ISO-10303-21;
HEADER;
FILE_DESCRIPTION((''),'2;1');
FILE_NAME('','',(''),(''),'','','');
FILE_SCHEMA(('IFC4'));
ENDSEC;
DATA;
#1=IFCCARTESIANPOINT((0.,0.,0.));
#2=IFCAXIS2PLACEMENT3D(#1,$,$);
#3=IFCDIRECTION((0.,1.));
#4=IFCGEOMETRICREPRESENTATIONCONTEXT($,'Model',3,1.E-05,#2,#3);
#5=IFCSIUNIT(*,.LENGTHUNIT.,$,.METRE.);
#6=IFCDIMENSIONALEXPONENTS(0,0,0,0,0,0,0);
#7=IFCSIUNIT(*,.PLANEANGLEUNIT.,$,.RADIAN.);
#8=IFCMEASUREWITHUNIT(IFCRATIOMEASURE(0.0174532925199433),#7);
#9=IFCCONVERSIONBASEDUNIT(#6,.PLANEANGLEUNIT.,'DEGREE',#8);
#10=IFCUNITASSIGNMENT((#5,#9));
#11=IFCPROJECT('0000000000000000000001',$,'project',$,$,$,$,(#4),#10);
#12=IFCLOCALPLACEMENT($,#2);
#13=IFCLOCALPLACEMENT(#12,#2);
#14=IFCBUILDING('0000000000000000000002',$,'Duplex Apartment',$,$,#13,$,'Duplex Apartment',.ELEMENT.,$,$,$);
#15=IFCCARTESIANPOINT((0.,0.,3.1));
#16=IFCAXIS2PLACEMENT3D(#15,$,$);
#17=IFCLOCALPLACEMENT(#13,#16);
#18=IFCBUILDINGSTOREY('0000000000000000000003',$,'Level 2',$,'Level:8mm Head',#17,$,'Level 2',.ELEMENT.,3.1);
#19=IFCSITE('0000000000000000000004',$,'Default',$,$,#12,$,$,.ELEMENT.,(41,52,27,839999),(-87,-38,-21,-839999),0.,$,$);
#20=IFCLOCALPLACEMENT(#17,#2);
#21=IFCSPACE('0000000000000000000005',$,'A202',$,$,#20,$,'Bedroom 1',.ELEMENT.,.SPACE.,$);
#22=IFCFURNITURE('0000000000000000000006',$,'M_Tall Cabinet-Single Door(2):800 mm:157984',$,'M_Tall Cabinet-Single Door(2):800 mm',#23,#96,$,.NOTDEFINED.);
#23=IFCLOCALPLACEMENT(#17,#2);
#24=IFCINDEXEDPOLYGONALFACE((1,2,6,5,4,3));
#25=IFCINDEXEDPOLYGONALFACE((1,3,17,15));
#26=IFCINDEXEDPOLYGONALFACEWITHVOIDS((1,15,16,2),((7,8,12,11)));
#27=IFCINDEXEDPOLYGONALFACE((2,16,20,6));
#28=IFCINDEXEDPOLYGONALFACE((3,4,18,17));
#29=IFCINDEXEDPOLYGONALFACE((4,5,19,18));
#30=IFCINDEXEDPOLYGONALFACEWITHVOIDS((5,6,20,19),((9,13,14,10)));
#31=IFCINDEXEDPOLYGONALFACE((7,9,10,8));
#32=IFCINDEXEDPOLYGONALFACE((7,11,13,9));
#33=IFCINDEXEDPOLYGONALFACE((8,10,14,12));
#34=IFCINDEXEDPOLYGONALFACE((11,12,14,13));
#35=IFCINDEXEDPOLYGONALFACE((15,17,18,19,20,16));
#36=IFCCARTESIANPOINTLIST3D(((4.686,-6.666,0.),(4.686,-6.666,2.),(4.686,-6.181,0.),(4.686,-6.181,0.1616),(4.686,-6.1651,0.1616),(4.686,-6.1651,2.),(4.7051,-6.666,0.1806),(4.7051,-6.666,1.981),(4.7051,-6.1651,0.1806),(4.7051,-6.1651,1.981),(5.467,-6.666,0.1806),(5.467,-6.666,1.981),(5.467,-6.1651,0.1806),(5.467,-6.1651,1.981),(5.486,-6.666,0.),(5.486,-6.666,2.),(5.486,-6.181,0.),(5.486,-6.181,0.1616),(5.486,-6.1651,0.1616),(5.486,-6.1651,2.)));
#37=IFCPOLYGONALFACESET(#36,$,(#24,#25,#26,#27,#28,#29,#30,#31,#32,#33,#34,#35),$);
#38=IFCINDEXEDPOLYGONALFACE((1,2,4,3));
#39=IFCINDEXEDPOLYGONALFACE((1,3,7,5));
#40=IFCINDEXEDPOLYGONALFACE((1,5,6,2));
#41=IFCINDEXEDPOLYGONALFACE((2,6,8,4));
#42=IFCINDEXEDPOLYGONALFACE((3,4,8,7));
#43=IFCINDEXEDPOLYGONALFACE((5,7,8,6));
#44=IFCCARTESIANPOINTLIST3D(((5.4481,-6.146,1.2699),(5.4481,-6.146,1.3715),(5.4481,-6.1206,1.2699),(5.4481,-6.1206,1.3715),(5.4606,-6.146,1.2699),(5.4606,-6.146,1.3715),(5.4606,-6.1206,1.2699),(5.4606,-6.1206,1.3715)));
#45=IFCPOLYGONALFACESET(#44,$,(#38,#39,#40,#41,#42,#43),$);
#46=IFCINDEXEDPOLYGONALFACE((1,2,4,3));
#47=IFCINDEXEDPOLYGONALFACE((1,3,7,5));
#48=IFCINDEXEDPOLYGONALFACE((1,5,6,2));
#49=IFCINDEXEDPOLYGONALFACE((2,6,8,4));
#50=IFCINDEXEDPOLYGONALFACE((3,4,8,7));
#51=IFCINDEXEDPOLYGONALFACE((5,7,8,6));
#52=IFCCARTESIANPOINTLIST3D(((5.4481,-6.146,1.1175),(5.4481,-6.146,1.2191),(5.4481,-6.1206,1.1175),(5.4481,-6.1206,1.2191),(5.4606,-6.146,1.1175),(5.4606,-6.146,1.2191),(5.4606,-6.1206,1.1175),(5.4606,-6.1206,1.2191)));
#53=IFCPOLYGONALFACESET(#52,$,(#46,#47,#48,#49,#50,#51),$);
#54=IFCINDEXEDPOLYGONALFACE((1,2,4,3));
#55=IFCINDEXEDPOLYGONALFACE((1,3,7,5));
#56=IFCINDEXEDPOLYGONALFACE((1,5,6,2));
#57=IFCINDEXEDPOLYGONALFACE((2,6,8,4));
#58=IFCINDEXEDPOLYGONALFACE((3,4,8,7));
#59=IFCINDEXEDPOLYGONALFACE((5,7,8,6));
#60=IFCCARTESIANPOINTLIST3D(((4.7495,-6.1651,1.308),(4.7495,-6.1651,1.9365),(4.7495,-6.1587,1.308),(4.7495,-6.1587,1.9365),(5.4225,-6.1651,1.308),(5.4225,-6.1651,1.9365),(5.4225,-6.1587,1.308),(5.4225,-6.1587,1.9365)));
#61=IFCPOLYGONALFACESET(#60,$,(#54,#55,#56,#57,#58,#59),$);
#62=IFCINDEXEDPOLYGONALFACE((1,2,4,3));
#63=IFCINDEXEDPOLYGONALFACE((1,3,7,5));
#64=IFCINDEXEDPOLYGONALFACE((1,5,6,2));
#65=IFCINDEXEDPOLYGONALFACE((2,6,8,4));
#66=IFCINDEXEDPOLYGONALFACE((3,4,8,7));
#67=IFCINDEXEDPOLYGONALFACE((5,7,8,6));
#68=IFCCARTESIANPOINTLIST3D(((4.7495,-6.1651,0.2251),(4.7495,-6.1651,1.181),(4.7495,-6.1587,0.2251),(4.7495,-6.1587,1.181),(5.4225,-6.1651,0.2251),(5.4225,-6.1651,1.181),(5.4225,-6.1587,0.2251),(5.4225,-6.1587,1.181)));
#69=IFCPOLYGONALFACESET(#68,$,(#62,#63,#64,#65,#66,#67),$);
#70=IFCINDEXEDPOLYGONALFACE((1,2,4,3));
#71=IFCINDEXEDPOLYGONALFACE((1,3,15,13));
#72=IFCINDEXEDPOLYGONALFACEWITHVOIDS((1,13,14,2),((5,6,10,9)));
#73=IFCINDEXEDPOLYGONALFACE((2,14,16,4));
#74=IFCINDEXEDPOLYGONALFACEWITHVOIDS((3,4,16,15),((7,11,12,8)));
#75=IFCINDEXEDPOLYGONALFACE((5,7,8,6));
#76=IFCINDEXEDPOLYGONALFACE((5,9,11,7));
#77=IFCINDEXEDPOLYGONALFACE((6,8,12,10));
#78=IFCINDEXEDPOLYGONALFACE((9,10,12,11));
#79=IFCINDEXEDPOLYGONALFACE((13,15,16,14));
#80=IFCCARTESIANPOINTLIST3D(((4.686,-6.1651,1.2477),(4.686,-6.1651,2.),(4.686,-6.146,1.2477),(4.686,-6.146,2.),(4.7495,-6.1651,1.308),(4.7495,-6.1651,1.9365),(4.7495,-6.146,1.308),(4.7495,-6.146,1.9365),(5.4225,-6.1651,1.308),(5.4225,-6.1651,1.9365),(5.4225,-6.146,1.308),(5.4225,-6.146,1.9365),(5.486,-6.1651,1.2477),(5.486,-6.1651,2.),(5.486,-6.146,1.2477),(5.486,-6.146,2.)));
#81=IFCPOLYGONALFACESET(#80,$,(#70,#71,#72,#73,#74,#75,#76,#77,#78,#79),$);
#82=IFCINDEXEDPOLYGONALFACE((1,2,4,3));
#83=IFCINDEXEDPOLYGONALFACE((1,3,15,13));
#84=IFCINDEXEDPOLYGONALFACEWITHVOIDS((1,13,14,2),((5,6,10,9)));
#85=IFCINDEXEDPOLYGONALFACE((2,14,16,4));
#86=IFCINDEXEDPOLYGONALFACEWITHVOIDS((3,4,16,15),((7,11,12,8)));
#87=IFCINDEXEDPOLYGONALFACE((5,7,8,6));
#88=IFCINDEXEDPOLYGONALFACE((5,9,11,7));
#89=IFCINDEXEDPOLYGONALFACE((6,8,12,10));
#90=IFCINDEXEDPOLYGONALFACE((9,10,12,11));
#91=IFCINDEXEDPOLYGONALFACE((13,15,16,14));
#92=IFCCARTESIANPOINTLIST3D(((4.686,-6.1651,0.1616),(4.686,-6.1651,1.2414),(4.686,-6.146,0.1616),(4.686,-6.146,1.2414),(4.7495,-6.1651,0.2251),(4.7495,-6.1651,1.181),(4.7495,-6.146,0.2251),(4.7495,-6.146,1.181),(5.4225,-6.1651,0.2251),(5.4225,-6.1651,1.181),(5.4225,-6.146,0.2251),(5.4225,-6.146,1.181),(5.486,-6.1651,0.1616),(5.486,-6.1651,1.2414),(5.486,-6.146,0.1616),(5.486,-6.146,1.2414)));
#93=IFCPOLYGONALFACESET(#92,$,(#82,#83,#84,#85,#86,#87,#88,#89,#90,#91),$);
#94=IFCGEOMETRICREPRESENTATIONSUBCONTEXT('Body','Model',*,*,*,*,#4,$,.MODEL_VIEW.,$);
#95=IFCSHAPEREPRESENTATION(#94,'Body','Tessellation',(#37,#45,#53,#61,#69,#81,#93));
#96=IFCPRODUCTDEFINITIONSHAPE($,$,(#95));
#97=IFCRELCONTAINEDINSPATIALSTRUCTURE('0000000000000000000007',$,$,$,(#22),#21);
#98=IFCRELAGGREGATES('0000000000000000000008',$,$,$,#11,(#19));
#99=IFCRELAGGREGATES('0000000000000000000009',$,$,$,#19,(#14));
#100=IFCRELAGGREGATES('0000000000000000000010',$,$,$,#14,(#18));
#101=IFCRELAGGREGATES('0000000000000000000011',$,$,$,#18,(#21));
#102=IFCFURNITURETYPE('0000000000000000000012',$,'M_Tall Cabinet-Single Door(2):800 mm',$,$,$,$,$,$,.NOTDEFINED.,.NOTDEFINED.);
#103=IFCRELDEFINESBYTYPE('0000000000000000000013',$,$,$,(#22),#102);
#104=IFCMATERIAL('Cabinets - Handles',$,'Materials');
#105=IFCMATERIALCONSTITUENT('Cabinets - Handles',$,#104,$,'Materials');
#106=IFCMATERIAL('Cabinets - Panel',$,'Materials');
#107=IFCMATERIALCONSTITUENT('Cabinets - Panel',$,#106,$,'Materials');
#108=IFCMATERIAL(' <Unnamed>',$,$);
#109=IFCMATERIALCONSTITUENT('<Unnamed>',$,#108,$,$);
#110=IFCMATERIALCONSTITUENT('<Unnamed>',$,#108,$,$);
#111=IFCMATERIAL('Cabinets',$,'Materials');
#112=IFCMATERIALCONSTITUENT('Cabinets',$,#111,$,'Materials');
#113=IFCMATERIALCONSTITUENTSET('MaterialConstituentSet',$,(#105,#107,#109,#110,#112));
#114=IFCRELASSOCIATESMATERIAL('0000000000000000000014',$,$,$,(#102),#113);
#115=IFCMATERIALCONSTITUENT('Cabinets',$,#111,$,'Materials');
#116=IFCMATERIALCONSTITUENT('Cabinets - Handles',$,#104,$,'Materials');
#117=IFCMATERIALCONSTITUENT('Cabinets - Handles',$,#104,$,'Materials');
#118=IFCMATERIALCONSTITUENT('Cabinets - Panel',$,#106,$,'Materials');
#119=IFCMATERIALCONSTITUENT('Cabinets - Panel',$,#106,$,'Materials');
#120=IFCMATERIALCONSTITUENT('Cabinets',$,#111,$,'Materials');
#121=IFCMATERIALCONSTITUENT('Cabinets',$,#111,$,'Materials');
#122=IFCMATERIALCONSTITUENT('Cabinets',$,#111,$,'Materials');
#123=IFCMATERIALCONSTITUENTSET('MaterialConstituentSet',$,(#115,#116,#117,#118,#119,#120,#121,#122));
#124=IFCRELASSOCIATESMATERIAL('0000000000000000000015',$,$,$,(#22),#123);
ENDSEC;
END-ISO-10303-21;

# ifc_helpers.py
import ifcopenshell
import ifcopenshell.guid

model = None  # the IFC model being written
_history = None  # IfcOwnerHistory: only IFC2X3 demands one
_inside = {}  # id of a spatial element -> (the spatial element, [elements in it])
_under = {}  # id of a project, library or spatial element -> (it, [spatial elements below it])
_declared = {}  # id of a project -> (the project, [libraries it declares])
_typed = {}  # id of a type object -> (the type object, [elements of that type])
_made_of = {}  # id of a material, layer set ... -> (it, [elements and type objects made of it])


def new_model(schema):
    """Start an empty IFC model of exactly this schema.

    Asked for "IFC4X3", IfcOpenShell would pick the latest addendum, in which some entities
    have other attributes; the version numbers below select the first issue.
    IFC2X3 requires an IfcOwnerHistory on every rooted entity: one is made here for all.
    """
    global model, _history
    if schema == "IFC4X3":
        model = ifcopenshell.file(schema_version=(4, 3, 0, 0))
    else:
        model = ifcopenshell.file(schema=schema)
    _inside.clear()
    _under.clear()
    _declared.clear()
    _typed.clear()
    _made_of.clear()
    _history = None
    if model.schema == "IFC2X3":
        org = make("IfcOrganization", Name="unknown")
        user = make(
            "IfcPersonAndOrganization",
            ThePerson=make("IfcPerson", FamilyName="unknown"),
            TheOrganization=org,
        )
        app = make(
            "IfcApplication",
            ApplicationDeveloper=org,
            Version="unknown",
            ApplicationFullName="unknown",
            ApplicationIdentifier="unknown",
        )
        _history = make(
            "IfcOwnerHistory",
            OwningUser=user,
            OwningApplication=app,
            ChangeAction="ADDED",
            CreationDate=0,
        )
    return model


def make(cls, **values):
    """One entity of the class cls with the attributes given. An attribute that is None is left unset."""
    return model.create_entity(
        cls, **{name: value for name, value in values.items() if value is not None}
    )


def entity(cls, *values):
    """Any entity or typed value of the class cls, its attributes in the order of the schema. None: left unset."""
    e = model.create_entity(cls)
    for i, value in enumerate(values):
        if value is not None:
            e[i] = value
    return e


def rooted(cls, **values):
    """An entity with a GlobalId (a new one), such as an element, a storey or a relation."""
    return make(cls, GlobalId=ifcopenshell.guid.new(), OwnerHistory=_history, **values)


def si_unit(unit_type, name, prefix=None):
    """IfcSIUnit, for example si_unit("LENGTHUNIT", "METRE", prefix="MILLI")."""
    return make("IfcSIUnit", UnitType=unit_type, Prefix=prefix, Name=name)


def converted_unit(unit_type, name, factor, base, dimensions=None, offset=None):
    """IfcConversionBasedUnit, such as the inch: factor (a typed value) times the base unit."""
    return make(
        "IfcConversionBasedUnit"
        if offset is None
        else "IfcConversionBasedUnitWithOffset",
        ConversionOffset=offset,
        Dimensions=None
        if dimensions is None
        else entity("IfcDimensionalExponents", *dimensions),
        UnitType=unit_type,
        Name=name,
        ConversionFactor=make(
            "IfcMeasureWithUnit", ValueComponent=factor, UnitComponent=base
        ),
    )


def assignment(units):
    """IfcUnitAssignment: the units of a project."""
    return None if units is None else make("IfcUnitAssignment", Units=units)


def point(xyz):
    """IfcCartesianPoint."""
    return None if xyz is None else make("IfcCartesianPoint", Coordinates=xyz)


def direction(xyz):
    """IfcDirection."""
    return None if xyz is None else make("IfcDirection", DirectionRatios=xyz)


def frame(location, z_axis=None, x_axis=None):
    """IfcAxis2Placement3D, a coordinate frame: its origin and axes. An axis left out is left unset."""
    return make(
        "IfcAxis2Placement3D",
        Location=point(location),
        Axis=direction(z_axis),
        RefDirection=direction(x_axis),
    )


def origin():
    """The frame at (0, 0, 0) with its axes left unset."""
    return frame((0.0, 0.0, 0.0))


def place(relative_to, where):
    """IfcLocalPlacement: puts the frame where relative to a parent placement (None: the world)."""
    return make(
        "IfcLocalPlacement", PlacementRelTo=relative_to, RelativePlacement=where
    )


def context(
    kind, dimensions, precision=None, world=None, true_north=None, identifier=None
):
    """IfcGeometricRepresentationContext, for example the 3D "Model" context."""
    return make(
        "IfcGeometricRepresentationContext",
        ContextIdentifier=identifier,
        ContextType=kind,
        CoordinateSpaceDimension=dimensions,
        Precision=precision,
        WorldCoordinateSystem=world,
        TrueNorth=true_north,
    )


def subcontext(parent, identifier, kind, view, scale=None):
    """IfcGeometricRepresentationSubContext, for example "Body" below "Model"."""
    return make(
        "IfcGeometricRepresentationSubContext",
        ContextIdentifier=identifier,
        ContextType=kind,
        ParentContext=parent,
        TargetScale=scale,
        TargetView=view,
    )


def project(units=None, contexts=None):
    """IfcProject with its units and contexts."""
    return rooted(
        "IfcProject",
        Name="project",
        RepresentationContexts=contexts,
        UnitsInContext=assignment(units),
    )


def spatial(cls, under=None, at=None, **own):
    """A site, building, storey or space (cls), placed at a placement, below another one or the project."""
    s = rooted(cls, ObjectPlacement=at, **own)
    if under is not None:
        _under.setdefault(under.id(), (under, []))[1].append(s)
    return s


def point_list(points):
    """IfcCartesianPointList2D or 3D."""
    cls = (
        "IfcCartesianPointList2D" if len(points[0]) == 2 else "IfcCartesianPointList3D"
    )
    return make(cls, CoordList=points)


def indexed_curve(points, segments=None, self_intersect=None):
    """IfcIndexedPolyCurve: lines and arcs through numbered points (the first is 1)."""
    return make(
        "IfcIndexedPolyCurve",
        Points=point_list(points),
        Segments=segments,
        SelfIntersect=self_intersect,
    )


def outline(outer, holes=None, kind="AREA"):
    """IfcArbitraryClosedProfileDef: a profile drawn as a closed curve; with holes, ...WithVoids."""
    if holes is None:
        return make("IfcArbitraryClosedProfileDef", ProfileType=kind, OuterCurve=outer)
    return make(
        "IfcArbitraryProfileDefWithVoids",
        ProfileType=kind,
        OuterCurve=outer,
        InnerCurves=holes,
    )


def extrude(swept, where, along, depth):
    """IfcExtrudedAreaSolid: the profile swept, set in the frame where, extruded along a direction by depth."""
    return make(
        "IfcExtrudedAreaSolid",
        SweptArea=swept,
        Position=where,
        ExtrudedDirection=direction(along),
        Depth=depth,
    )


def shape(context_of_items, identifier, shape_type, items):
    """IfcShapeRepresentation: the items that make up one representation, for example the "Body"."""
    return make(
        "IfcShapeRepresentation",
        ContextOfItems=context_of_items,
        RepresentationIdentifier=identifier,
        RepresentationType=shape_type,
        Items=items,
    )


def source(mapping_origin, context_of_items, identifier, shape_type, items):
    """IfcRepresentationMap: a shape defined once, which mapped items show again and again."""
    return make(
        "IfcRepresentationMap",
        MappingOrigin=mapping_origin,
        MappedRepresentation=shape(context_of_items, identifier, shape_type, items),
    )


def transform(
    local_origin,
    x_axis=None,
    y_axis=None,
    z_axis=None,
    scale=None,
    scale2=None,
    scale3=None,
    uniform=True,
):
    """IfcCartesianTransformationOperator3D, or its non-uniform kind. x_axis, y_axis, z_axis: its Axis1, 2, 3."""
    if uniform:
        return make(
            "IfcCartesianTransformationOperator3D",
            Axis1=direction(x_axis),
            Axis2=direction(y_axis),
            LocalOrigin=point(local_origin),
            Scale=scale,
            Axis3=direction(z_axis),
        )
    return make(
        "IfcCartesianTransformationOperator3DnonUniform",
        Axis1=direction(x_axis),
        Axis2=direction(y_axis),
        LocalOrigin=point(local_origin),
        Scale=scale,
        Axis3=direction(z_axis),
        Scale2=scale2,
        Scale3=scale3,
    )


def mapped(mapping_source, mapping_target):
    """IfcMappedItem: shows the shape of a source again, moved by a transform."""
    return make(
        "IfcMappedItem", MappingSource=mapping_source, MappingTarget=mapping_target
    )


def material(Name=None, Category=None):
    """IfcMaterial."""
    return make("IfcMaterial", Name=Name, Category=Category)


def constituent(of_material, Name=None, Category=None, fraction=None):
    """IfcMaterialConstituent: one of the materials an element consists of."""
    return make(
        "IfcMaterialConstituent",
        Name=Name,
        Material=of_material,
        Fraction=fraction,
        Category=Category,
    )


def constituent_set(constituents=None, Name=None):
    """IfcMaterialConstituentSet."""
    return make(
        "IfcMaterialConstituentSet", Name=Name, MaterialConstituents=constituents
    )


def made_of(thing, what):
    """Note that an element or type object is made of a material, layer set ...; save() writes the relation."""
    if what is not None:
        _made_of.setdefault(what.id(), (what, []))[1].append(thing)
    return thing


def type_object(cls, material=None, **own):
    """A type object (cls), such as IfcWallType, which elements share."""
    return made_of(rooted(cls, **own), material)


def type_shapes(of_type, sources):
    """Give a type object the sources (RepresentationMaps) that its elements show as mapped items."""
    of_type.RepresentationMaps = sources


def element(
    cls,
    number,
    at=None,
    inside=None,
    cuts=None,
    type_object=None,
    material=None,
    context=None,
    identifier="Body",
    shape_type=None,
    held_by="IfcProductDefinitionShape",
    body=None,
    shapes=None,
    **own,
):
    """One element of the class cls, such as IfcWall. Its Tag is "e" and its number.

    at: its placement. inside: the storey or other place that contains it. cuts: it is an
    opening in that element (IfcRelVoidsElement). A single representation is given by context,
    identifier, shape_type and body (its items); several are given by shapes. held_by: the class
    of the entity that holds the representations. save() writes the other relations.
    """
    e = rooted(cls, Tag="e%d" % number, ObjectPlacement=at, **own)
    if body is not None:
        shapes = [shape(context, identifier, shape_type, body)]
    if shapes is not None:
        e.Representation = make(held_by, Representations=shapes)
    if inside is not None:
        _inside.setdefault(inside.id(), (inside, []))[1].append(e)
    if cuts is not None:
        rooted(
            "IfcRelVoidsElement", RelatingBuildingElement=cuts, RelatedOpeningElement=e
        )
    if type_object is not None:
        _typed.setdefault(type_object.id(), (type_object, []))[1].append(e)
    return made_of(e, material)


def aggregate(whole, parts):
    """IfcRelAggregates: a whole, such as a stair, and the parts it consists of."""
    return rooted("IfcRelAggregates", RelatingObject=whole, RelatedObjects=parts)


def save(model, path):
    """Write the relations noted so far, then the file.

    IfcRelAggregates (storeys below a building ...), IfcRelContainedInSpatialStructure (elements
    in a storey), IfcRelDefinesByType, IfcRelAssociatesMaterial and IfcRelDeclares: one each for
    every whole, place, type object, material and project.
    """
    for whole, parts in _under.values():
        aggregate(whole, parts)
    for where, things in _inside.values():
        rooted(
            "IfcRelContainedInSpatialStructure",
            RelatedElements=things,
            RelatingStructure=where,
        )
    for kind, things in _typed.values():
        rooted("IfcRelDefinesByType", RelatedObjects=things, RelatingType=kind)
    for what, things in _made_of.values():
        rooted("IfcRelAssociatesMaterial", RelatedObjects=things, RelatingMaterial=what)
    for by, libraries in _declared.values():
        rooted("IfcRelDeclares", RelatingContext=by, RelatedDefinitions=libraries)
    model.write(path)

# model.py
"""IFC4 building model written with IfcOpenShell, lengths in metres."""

from ifc_helpers import new_model, entity, si_unit, converted_unit, direction, frame, origin, place, context, subcontext, project, spatial, indexed_curve, outline, extrude, source, transform, mapped, material, constituent, constituent_set, type_object, type_shapes, element, save


model = new_model("IFC4")

# Units and contexts
model_context = context("Model", 3, precision=1e-05, world=origin(), true_north=direction((0.0, 1.0)))
body_context = subcontext(model_context, "Body", "Model", "MODEL_VIEW")
ifc_project = project(units=[si_unit("LENGTHUNIT", "METRE"), converted_unit("PLANEANGLEUNIT", "DEGREE", entity("IfcRatioMeasure", 0.0174532925199433), si_unit("PLANEANGLEUNIT", "RADIAN"), dimensions=[0, 0, 0, 0, 0, 0, 0])], contexts=[model_context])

# Site, building, storey
site_placement = place(None, origin())
site = spatial("IfcSite", under=ifc_project, at=site_placement, Name="Default", CompositionType="ELEMENT", RefLatitude=(41, 52, 27, 839999), RefLongitude=(-87, -38, -21, -839999), RefElevation=0.0)
building_placement = place(site_placement, origin())
building = spatial("IfcBuilding", under=site, at=building_placement, Name="Duplex Apartment", LongName="Duplex Apartment", CompositionType="ELEMENT")
storey_placement = place(building_placement, frame((0.0, 0.0, 3.1)))
storey = spatial("IfcBuildingStorey", under=building, at=storey_placement, Name="Level 2", ObjectType="Level:8mm Head", LongName="Level 2", CompositionType="ELEMENT", Elevation=3.1)

# Shared definitions
ifc_material_1 = material(Name="Cabinets", Category="Materials")
ifc_material_2 = material(Name="Cabinets - Handles", Category="Materials")
ifc_material_3 = material(Name="Cabinets - Panel", Category="Materials")
ifc_material_4 = material(Name=" <Unnamed>")

# Shared definitions
space_1_placement = place(storey_placement, origin())
space_1 = spatial("IfcSpace", under=storey, at=space_1_placement, Name="A202", LongName="Bedroom 1", CompositionType="ELEMENT", PredefinedType="SPACE")

# Furniture, opening
ifc_constituent_1 = constituent(ifc_material_1, Name="Cabinets", Category="Materials")
ifc_constituent_2 = constituent(ifc_material_2, Name="Cabinets - Handles", Category="Materials")
ifc_constituent_3 = constituent(ifc_material_2, Name="Cabinets - Handles", Category="Materials")
ifc_constituent_4 = constituent(ifc_material_3, Name="Cabinets - Panel", Category="Materials")
ifc_constituent_5 = constituent(ifc_material_3, Name="Cabinets - Panel", Category="Materials")
ifc_constituent_6 = constituent(ifc_material_1, Name="Cabinets", Category="Materials")
ifc_constituent_7 = constituent(ifc_material_1, Name="Cabinets", Category="Materials")
ifc_constituent_8 = constituent(ifc_material_1, Name="Cabinets", Category="Materials")
ifc_constituent_set_1 = constituent_set(constituents=[ifc_constituent_1, ifc_constituent_2, ifc_constituent_3, ifc_constituent_4, ifc_constituent_5, ifc_constituent_6, ifc_constituent_7, ifc_constituent_8], Name="MaterialConstituentSet")
ifc_constituent_9 = constituent(ifc_material_2, Name="Cabinets - Handles", Category="Materials")
ifc_constituent_10 = constituent(ifc_material_3, Name="Cabinets - Panel", Category="Materials")
ifc_constituent_11 = constituent(ifc_material_4, Name="<Unnamed>")
ifc_constituent_12 = constituent(ifc_material_4, Name="<Unnamed>")
ifc_constituent_13 = constituent(ifc_material_1, Name="Cabinets", Category="Materials")
ifc_constituent_set_2 = constituent_set(constituents=[ifc_constituent_9, ifc_constituent_10, ifc_constituent_11, ifc_constituent_12, ifc_constituent_13], Name="MaterialConstituentSet")
furniture_type_1 = type_object("IfcFurnitureType", Name="M_Tall Cabinet-Single Door(2):800 mm", AssemblyPlace="NOTDEFINED", PredefinedType="NOTDEFINED", material=ifc_constituent_set_2)
shared_shape_1 = source(origin(), body_context, "Body", "SweptSolid", [
    extrude(outline(indexed_curve([(-0.5589, -0.1723), (1.2795, -0.1723), (1.2795, 0.3286), (-0.7205, 0.3286), (-0.7205, -0.1563), (-0.5589, -0.1563), (-0.5589, -0.1723)], self_intersect=False)), frame((-0.3813, 0.3286, 0.7205), z_axis=(1.0, 0.0, 0.0), x_axis=(0.0, 0.0, 1.0)), (0.0, 0.0, 1.0), 0.8),
    extrude(outline(indexed_curve([(-0.0063, -0.0127), (0.0063, -0.0127), (0.0063, 0.0127), (-0.0063, 0.0127), (-0.0063, -0.0127)], self_intersect=False)), frame((0.3871, 0.5327, 1.2699), z_axis=(0.0, 0.0, 1.0), x_axis=(-1.0, 0.0, 0.0)), (0.0, 0.0, 1.0), 0.1016),
    extrude(outline(indexed_curve([(-0.0063, -0.0127), (0.0063, -0.0127), (0.0063, 0.0127), (-0.0063, 0.0127), (-0.0063, -0.0127)], self_intersect=False)), frame((0.3871, 0.5327, 1.1175), z_axis=(0.0, 0.0, 1.0), x_axis=(-1.0, 0.0, 0.0)), (0.0, 0.0, 1.0), 0.1016),
    extrude(outline(indexed_curve([(-0.3365, -0.0032), (0.3365, -0.0032), (0.3365, 0.0032), (-0.3365, 0.0032), (-0.3365, -0.0032)], self_intersect=False)), frame((0.0187, 0.5041, 1.308), z_axis=(0.0, 0.0, 1.0), x_axis=(-1.0, 0.0, 0.0)), (0.0, 0.0, 1.0), 0.6285),
    extrude(outline(indexed_curve([(-0.3365, -0.0032), (0.3365, -0.0032), (0.3365, 0.0032), (-0.3365, 0.0032), (-0.3365, -0.0032)], self_intersect=False)), frame((0.0187, 0.5041, 0.2251), z_axis=(0.0, 0.0, 1.0), x_axis=(-1.0, 0.0, 0.0)), (0.0, 0.0, 1.0), 0.956),
    extrude(outline(indexed_curve([(-0.3761, -0.4), (0.3761, -0.4), (0.3761, 0.4), (-0.3761, 0.4), (-0.3761, -0.4)], self_intersect=False), holes=[indexed_curve([(-0.3126, -0.3365), (-0.3126, 0.3365), (0.3158, 0.3365), (0.3158, -0.3365), (-0.3126, -0.3365)], self_intersect=False)]), frame((0.0187, 0.501, 1.6239), z_axis=(0.0, 1.0, 0.0), x_axis=(0.0, 0.0, -1.0)), (0.0, 0.0, 1.0), 0.0191),
    extrude(outline(indexed_curve([(-0.4, -0.5399), (0.4, -0.5399), (0.4, 0.5399), (-0.4, 0.5399), (-0.4, -0.5399)], self_intersect=False), holes=[indexed_curve([(-0.3365, 0.4796), (0.3365, 0.4796), (0.3365, -0.4764), (-0.3365, -0.4764), (-0.3365, 0.4796)], self_intersect=False)]), frame((0.0187, 0.501, 0.7015), z_axis=(0.0, 1.0, 0.0), x_axis=(-1.0, 0.0, 0.0)), (0.0, 0.0, 1.0), 0.0191),
    extrude(outline(indexed_curve([(-0.381, -0.0095), (0.381, -0.0095), (0.381, 0.0095), (-0.381, 0.0095), (-0.381, -0.0095)], self_intersect=False)), frame((0.0187, 0.0095, 0.1806), z_axis=(0.0, 0.0, 1.0), x_axis=(-1.0, 0.0, 0.0)), (0.0, 0.0, 1.0), 1.8003),
])
type_shapes(furniture_type_1, [shared_shape_1])
furniture_1_placement = place(space_1_placement, frame((5.0673, -6.666, 0.0)))
furniture_1 = element("IfcFurniture", 1, at=furniture_1_placement, inside=space_1, type_object=furniture_type_1, material=ifc_constituent_set_1, Name="M_Tall Cabinet-Single Door(2):800 mm:157984", ObjectType="M_Tall Cabinet-Single Door(2):800 mm", PredefinedType="NOTDEFINED", context=body_context, shape_type="MappedRepresentation", body=[
    mapped(shared_shape_1, transform((0.0, 0.0, 0.0), scale=1.0)),
])
opening_1_placement = place(storey_placement, frame((5.0673, -6.666, 3.1)))
element("IfcOpeningElement", 2, at=opening_1_placement, cuts=furniture_1, ObjectType="Opening", PredefinedType="OPENING", context=body_context, shape_type="SweptSolid", body=[
    extrude(outline(indexed_curve([(-0.9002, -0.381), (0.9002, -0.381), (0.9002, 0.381), (-0.9002, 0.381), (-0.9002, -0.381)], self_intersect=False)), frame((0.0187, 0.0, -2.0192), z_axis=(0.0, 1.0, 0.0), x_axis=(0.0, 0.0, -1.0)), (0.0, 0.0, 1.0), 0.501),
])

save(model, "model.ifc")
